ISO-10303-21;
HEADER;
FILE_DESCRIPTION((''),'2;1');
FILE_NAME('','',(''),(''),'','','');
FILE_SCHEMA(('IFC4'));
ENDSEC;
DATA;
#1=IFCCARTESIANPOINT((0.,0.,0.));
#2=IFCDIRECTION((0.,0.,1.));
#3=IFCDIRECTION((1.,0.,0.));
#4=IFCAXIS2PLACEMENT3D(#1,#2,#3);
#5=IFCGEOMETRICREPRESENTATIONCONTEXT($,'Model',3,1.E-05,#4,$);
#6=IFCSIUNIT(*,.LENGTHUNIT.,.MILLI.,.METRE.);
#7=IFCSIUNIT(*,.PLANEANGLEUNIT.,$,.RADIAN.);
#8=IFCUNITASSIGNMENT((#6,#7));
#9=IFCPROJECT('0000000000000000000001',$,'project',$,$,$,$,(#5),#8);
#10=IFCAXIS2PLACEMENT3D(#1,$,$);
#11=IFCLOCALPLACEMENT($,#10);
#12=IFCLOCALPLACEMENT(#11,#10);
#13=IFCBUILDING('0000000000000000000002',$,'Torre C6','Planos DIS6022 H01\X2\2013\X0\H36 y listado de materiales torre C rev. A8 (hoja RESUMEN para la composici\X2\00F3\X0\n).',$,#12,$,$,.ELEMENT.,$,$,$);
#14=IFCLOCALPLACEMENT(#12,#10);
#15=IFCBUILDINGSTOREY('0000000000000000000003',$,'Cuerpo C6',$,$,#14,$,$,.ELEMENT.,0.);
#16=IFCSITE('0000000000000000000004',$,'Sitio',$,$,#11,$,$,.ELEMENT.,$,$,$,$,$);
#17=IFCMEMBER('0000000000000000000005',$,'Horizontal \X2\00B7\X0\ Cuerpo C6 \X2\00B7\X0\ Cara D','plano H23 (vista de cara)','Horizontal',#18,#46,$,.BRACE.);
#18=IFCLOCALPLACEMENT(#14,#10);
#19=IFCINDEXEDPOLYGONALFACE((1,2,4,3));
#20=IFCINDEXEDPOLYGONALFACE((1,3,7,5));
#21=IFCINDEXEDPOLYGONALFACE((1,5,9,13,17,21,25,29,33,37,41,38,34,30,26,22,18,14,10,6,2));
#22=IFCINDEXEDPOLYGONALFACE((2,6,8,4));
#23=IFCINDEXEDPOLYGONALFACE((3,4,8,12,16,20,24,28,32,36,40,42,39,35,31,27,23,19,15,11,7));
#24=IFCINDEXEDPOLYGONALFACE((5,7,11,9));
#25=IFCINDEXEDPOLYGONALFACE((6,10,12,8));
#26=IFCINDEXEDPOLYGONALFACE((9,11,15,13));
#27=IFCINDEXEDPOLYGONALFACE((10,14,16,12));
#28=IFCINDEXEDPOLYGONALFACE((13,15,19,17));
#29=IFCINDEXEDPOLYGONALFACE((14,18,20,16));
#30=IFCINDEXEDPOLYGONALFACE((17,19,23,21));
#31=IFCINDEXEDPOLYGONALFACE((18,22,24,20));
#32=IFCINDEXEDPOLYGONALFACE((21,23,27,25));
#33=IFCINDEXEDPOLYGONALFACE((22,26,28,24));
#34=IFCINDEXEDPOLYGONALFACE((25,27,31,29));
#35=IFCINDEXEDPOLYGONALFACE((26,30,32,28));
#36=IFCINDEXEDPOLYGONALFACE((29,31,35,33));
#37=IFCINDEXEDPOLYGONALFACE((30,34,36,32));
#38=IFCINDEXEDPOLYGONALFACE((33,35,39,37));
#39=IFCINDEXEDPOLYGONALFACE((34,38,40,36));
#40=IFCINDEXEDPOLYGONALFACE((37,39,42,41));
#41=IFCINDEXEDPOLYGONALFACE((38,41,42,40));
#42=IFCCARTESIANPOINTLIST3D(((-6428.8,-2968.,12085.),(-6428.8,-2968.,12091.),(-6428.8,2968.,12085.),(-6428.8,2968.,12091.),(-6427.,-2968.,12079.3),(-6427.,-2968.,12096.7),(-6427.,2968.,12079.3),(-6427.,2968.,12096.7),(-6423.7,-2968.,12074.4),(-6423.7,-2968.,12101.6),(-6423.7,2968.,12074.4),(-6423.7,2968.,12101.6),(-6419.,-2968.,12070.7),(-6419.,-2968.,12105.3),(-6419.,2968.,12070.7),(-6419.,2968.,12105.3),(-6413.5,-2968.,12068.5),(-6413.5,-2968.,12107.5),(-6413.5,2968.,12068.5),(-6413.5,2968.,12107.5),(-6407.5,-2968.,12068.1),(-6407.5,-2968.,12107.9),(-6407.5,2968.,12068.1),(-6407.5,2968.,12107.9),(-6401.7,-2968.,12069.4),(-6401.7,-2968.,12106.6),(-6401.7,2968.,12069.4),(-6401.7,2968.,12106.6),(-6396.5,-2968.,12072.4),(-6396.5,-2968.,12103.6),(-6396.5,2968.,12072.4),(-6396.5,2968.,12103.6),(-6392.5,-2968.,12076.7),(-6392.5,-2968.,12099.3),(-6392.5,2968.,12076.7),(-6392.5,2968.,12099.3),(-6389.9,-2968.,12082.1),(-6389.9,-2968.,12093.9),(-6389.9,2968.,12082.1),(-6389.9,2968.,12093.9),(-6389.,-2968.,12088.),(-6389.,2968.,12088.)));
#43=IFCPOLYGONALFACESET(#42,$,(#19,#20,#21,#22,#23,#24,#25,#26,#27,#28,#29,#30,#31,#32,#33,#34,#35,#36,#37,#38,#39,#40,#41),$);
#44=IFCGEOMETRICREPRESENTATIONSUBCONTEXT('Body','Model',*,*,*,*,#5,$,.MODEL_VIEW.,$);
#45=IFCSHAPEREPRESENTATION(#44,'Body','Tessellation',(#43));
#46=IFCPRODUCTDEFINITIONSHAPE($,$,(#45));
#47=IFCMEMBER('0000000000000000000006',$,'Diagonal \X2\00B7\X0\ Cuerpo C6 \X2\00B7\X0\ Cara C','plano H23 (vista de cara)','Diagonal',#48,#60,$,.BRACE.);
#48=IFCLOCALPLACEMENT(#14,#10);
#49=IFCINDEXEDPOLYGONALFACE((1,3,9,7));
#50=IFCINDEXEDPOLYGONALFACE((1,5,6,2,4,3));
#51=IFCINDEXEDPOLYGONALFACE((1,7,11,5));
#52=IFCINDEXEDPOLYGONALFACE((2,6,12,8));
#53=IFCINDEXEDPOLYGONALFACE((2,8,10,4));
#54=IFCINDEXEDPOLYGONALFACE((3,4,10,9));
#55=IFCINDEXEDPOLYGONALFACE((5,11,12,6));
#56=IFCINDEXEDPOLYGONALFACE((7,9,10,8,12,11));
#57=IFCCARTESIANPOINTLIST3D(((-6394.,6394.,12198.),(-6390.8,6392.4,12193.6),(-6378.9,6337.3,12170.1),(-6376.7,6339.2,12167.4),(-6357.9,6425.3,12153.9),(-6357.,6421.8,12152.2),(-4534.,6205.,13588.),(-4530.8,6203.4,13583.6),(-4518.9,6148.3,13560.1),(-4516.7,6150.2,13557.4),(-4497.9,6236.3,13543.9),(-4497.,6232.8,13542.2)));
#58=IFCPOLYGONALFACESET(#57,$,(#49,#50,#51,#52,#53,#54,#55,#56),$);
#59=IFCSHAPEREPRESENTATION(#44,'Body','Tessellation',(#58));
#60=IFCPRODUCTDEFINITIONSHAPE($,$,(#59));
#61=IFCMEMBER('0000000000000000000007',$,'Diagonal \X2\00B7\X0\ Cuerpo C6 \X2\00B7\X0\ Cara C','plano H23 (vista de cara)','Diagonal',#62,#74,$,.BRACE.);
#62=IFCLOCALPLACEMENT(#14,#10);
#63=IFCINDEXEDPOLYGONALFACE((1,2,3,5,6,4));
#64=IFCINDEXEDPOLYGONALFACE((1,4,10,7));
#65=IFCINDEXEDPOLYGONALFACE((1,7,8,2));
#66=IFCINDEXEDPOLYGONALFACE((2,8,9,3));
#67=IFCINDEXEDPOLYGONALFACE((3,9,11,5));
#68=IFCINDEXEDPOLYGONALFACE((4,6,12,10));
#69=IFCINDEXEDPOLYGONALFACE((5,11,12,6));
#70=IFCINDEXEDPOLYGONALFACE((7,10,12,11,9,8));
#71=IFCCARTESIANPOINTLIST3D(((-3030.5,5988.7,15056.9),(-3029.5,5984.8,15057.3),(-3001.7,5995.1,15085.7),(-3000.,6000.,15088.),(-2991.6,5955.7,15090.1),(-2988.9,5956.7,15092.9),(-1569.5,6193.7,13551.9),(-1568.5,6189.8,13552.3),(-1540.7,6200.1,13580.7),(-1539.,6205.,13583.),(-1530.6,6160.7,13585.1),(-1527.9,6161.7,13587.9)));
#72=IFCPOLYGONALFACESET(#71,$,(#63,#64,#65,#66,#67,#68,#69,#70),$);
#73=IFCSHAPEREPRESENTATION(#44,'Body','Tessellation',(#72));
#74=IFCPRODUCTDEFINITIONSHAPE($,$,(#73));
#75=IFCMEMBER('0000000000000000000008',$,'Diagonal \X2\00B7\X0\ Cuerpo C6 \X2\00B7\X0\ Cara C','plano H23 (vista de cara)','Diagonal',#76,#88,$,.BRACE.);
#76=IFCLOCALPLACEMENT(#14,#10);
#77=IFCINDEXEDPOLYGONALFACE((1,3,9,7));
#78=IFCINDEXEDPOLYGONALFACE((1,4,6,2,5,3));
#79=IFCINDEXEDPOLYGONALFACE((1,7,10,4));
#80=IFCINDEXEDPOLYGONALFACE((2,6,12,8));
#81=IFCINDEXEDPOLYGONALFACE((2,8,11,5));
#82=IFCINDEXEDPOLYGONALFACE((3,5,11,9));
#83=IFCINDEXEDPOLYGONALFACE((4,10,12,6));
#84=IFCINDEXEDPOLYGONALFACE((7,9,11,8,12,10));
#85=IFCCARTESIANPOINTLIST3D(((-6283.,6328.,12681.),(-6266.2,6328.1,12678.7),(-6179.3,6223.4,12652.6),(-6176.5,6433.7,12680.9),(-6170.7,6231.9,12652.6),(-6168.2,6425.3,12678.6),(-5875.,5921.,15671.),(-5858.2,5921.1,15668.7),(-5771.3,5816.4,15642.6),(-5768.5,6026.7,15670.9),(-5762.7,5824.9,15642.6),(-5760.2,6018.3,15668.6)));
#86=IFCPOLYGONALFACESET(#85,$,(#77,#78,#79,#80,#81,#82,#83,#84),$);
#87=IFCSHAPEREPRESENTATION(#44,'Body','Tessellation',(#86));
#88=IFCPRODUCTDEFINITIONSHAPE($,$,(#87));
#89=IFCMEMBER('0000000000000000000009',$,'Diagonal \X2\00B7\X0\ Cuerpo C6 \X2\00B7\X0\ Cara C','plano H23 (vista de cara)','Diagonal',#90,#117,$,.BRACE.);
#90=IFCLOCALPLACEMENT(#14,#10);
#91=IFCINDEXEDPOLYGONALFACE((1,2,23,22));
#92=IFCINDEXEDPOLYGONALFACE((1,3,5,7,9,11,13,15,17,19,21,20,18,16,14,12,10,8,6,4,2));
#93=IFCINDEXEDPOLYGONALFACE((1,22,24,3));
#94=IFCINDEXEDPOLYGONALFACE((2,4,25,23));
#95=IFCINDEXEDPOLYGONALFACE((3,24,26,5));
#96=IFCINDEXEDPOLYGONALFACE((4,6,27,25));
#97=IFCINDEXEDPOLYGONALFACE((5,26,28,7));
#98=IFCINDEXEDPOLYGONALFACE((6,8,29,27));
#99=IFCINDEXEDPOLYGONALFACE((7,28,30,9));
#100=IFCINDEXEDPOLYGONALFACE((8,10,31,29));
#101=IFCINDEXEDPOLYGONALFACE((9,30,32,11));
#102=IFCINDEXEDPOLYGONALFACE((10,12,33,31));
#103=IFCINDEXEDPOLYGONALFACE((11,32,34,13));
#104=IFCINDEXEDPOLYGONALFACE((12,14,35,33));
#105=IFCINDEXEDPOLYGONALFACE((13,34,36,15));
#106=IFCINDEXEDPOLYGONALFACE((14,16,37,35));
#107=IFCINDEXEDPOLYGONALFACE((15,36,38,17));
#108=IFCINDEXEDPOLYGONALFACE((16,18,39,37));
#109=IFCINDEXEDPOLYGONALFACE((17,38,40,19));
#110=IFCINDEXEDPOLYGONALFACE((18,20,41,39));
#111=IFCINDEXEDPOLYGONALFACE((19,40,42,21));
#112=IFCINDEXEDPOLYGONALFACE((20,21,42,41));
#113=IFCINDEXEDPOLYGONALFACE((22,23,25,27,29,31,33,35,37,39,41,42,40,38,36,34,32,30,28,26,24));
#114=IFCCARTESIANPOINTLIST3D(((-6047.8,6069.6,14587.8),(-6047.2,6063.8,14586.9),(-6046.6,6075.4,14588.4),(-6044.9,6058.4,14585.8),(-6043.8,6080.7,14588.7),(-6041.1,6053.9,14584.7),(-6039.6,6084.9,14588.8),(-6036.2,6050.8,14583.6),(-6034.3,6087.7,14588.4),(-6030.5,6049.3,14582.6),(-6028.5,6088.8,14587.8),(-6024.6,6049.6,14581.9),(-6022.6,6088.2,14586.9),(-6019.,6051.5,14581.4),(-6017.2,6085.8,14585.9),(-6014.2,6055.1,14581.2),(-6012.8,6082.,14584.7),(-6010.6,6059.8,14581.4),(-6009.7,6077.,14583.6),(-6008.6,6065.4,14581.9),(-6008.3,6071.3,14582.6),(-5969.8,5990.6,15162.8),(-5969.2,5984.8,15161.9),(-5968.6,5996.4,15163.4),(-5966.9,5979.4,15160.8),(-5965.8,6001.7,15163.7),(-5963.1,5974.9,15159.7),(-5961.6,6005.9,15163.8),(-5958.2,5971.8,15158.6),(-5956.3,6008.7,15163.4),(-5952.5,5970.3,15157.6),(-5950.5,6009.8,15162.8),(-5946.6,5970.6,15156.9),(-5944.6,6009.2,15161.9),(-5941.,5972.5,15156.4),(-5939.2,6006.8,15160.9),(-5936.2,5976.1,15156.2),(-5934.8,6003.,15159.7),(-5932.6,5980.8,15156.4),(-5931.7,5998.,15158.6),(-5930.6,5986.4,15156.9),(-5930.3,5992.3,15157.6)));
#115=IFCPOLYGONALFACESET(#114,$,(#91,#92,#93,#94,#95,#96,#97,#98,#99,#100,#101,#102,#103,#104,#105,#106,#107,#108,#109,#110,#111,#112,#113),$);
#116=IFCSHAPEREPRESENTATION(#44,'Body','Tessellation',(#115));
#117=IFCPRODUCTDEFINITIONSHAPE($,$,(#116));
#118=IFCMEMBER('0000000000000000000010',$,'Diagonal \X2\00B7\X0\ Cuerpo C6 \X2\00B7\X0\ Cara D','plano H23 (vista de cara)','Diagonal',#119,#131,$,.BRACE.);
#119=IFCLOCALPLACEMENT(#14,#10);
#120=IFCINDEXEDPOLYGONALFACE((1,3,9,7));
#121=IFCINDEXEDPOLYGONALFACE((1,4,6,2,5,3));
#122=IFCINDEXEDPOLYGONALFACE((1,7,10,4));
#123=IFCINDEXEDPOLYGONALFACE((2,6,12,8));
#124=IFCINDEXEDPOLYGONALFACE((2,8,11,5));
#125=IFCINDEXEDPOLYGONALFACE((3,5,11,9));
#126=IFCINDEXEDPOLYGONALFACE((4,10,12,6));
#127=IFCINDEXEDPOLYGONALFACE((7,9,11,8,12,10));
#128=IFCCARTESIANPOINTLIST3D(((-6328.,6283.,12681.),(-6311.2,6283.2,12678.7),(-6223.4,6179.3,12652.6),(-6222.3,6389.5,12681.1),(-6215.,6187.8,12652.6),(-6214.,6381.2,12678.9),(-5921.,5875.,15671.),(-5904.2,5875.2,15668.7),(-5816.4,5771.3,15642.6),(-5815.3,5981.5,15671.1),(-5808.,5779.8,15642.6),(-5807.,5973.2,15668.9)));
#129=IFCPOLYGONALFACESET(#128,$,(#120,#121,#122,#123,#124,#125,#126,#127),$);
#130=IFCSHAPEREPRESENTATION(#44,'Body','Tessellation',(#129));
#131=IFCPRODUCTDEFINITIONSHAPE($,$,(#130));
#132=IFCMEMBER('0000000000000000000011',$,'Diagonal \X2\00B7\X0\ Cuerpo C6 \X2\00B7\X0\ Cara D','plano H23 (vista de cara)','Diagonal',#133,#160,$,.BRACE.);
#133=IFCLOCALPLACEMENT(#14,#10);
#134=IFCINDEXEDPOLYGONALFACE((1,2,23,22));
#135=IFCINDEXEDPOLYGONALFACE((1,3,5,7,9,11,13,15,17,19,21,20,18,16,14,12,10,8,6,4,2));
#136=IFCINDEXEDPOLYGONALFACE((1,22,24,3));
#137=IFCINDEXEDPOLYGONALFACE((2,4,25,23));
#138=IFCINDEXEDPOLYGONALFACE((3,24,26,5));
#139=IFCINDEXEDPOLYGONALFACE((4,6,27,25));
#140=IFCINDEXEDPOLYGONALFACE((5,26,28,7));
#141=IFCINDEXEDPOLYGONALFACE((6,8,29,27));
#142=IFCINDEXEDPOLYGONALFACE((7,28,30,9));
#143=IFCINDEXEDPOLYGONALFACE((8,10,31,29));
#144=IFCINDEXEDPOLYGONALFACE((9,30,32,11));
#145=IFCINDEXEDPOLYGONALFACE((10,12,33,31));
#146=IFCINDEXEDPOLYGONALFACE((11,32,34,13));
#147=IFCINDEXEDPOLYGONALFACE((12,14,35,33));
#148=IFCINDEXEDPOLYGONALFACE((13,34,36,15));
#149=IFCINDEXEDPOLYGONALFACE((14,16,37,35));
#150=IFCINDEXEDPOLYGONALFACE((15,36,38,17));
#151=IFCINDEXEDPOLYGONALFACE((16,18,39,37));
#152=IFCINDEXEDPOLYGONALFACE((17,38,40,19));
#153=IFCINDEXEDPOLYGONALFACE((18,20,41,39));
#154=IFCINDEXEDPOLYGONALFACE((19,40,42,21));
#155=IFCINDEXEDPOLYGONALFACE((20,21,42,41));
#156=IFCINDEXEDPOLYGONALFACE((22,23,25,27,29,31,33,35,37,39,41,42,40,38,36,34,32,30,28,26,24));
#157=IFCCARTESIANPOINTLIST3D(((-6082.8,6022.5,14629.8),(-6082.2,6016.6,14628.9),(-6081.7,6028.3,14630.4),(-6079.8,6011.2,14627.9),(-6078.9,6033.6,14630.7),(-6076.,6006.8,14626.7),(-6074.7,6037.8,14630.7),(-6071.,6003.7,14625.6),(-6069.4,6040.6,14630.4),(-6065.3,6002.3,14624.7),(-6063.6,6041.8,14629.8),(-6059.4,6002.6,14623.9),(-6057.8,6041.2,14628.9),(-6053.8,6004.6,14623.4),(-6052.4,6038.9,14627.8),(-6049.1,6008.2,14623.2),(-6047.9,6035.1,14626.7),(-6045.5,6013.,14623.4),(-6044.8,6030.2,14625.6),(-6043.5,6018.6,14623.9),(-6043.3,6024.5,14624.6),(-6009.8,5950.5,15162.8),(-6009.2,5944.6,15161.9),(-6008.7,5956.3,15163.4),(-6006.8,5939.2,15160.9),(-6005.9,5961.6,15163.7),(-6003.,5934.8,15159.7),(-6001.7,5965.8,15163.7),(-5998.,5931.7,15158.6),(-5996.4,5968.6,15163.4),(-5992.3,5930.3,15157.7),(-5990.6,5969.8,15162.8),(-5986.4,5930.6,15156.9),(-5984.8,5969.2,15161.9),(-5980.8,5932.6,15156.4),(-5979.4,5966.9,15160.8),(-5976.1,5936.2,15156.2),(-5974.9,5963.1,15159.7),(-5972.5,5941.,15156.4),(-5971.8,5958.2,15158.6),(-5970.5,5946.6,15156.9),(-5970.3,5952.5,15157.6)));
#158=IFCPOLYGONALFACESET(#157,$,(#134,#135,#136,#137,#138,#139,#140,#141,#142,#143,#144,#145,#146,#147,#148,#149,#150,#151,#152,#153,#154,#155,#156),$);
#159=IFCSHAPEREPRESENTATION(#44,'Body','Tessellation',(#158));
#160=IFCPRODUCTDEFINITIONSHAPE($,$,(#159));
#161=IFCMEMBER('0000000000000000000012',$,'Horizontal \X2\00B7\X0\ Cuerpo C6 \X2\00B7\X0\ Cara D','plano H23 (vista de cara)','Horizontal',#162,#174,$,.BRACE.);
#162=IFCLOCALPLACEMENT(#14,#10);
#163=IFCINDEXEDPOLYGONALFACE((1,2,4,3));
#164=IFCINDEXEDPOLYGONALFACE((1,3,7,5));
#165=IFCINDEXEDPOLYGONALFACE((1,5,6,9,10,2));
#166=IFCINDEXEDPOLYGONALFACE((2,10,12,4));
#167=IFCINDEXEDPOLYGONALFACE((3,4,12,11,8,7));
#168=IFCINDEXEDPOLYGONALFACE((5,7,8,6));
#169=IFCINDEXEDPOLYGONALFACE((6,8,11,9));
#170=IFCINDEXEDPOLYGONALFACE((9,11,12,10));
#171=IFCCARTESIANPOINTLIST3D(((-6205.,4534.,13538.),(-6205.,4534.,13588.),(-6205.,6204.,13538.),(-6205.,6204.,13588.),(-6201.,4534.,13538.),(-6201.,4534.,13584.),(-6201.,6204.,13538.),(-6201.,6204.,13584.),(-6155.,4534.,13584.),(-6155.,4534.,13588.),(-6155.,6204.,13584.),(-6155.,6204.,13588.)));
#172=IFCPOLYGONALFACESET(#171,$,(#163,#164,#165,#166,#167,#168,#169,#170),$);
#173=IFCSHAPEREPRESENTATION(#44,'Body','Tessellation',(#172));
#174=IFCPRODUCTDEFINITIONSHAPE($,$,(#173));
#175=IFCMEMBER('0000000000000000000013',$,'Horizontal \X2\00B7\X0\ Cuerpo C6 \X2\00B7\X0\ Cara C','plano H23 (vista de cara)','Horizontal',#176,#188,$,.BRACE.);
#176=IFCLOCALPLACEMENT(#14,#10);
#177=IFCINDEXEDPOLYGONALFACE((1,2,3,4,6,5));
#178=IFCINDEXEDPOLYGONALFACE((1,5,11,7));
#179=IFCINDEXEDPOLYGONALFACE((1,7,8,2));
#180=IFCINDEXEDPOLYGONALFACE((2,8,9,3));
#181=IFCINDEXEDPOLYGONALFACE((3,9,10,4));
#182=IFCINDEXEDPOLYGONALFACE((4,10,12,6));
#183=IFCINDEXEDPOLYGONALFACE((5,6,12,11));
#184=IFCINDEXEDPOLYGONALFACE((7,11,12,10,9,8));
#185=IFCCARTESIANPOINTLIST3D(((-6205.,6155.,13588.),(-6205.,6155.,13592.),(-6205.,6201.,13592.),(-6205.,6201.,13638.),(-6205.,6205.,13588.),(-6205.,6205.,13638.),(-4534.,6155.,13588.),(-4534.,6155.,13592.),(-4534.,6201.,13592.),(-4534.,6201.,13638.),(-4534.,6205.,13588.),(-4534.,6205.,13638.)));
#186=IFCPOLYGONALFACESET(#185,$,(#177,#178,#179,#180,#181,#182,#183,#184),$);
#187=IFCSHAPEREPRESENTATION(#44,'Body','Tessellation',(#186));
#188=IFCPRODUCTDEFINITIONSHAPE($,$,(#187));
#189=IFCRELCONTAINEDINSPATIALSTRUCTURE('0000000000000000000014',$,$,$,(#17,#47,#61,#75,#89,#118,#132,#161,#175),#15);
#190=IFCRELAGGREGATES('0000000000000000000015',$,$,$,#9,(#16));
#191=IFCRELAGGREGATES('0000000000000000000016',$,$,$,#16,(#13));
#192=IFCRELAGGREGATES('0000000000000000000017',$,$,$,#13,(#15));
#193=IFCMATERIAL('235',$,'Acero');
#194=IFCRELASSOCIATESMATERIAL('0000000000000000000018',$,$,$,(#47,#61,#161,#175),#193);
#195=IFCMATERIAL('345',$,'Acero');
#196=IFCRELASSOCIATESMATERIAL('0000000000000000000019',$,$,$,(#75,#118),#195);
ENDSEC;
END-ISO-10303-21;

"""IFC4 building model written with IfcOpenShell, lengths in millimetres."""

from ifc_helpers import new_model, si_unit, frame, frame_2d, origin, origin_with_axes, place, context, subcontext, project, spatial, circle, l_section, extrude, material, element, save


model = new_model("IFC4")

# Units and contexts
model_context = context("Model", 3, precision=1e-05, world=origin_with_axes())
body_context = subcontext(model_context, "Body", "Model", "MODEL_VIEW")
ifc_project = project(units=[si_unit("LENGTHUNIT", "METRE", prefix="MILLI"), si_unit("PLANEANGLEUNIT", "RADIAN")], contexts=[model_context])

# Site, building, storey
site_placement = place(None, origin())
site = spatial("IfcSite", under=ifc_project, at=site_placement, Name="Sitio", CompositionType="ELEMENT")
building_placement = place(site_placement, origin())
building = spatial("IfcBuilding", under=site, at=building_placement, Name="Torre C6", Description="Planos DIS6022 H01–H36 y listado de materiales torre C rev. A8 (hoja RESUMEN para la composición).", CompositionType="ELEMENT")
storey_placement = place(building_placement, origin())
storey = spatial("IfcBuildingStorey", under=building, at=storey_placement, Name="Cuerpo C6", CompositionType="ELEMENT", Elevation=0.0)

# Members
ifc_material_1 = material(Name="235", Category="Acero")
member_1_placement = place(storey_placement, frame((-6409.0, 2968.0, 12088.0), z_axis=(0.0, -1.0, 0.0), x_axis=(1.0, 0.0, 0.0)))
element("IfcMember", 1, at=member_1_placement, inside=storey, Name="Horizontal · Cuerpo C6 · Cara D", Description="plano H23 (vista de cara)", ObjectType="Horizontal", PredefinedType="BRACE", context=body_context, shape_type="SweptSolid", body=[
    extrude(circle(Radius=20.0), None, (0.0, 0.0, 1.0), 5936.0),
])
member_2_placement = place(storey_placement, frame((-6394.0, 6394.0, 12198.0), z_axis=(0.798392, -0.081127, 0.596648), x_axis=(0.23247, -0.872527, -0.429714)))
element("IfcMember", 2, at=member_2_placement, inside=storey, material=ifc_material_1, Name="Diagonal · Cuerpo C6 · Cara C", Description="plano H23 (vista de cara)", ObjectType="Diagonal", PredefinedType="BRACE", context=body_context, shape_type="SweptSolid", body=[
    extrude(l_section(Depth=65.0, Width=65.0, Thickness=4.0, at=frame_2d((32.5, 32.5))), None, (0.0, 0.0, 1.0), 2329.7),
])
member_3_placement = place(storey_placement, frame((-3000.0, 6000.0, 15088.0), z_axis=(0.693237, 0.097271, -0.714115), x_axis=(0.247072, -0.962882, 0.108692)))
element("IfcMember", 3, at=member_3_placement, inside=storey, material=ifc_material_1, Name="Diagonal · Cuerpo C6 · Cara C", Description="plano H23 (vista de cara)", ObjectType="Diagonal", PredefinedType="BRACE", context=body_context, shape_type="SweptSolid", body=[
    extrude(l_section(Depth=45.0, Width=45.0, Thickness=4.0, at=frame_2d((22.5, 22.5))), None, (0.0, 0.0, 1.0), 2107.5),
])
ifc_material_2 = material(Name="345", Category="Acero")
member_4_placement = place(storey_placement, frame((-6283.0, 6328.0, 12681.0), z_axis=(0.133989, -0.13366, 0.981928), x_axis=(0.691606, -0.697039, -0.189254)))
element("IfcMember", 4, at=member_4_placement, inside=storey, material=ifc_material_2, Name="Diagonal · Cuerpo C6 · Cara C", Description="plano H23 (vista de cara)", ObjectType="Diagonal", PredefinedType="BRACE", context=body_context, shape_type="SweptSolid", body=[
    extrude(l_section(Depth=150.0, Width=150.0, Thickness=12.0, at=frame_2d((75.0, 75.0))), None, (0.0, 0.0, 1.0), 3045.0),
])
member_5_placement = place(storey_placement, frame((-5950.0, 5990.0, 15160.0), z_axis=(-0.133192, 0.1349, -0.981866), x_axis=(0.692019, -0.696543, -0.189573)))
element("IfcMember", 5, at=member_5_placement, inside=storey, Name="Diagonal · Cuerpo C6 · Cara C", Description="plano H23 (vista de cara)", ObjectType="Diagonal", PredefinedType="BRACE", context=body_context, shape_type="SweptSolid", body=[
    extrude(circle(Radius=20.0), None, (0.0, 0.0, 1.0), 585.6),
])
member_6_placement = place(storey_placement, frame((-6328.0, 6283.0, 12681.0), z_axis=(0.13366, -0.133989, 0.981928), x_axis=(0.697039, -0.691606, -0.189254)))
element("IfcMember", 6, at=member_6_placement, inside=storey, material=ifc_material_2, Name="Diagonal · Cuerpo C6 · Cara D", Description="plano H23 (vista de cara)", ObjectType="Diagonal", PredefinedType="BRACE", context=body_context, shape_type="SweptSolid", body=[
    extrude(l_section(Depth=150.0, Width=150.0, Thickness=12.0, at=frame_2d((75.0, 75.0))), None, (0.0, 0.0, 1.0), 3045.0),
])
member_7_placement = place(storey_placement, frame((-5990.0, 5950.0, 15160.0), z_axis=(-0.134495, 0.132652, -0.981995), x_axis=(0.696622, -0.692121, -0.188905)))
element("IfcMember", 7, at=member_7_placement, inside=storey, Name="Diagonal · Cuerpo C6 · Cara D", Description="plano H23 (vista de cara)", ObjectType="Diagonal", PredefinedType="BRACE", context=body_context, shape_type="SweptSolid", body=[
    extrude(circle(Radius=20.0), None, (0.0, 0.0, 1.0), 542.8),
])
member_8_placement = place(storey_placement, frame((-6205.0, 4534.0, 13588.0), z_axis=(0.0, 1.0, 0.0), x_axis=(1.0, 0.0, 0.0)))
element("IfcMember", 8, at=member_8_placement, inside=storey, material=ifc_material_1, Name="Horizontal · Cuerpo C6 · Cara D", Description="plano H23 (vista de cara)", ObjectType="Horizontal", PredefinedType="BRACE", context=body_context, shape_type="SweptSolid", body=[
    extrude(l_section(Depth=50.0, Width=50.0, Thickness=4.0, at=frame_2d((25.0, 25.0))), None, (0.0, 0.0, 1.0), 1670.0),
])
member_9_placement = place(storey_placement, frame((-4534.0, 6205.0, 13588.0), z_axis=(-1.0, 0.0, 0.0), x_axis=(0.0, -1.0, 0.0)))
element("IfcMember", 9, at=member_9_placement, inside=storey, material=ifc_material_1, Name="Horizontal · Cuerpo C6 · Cara C", Description="plano H23 (vista de cara)", ObjectType="Horizontal", PredefinedType="BRACE", context=body_context, shape_type="SweptSolid", body=[
    extrude(l_section(Depth=50.0, Width=50.0, Thickness=4.0, at=frame_2d((25.0, 25.0))), None, (0.0, 0.0, 1.0), 1671.0),
])

save(model, "model.ifc")
